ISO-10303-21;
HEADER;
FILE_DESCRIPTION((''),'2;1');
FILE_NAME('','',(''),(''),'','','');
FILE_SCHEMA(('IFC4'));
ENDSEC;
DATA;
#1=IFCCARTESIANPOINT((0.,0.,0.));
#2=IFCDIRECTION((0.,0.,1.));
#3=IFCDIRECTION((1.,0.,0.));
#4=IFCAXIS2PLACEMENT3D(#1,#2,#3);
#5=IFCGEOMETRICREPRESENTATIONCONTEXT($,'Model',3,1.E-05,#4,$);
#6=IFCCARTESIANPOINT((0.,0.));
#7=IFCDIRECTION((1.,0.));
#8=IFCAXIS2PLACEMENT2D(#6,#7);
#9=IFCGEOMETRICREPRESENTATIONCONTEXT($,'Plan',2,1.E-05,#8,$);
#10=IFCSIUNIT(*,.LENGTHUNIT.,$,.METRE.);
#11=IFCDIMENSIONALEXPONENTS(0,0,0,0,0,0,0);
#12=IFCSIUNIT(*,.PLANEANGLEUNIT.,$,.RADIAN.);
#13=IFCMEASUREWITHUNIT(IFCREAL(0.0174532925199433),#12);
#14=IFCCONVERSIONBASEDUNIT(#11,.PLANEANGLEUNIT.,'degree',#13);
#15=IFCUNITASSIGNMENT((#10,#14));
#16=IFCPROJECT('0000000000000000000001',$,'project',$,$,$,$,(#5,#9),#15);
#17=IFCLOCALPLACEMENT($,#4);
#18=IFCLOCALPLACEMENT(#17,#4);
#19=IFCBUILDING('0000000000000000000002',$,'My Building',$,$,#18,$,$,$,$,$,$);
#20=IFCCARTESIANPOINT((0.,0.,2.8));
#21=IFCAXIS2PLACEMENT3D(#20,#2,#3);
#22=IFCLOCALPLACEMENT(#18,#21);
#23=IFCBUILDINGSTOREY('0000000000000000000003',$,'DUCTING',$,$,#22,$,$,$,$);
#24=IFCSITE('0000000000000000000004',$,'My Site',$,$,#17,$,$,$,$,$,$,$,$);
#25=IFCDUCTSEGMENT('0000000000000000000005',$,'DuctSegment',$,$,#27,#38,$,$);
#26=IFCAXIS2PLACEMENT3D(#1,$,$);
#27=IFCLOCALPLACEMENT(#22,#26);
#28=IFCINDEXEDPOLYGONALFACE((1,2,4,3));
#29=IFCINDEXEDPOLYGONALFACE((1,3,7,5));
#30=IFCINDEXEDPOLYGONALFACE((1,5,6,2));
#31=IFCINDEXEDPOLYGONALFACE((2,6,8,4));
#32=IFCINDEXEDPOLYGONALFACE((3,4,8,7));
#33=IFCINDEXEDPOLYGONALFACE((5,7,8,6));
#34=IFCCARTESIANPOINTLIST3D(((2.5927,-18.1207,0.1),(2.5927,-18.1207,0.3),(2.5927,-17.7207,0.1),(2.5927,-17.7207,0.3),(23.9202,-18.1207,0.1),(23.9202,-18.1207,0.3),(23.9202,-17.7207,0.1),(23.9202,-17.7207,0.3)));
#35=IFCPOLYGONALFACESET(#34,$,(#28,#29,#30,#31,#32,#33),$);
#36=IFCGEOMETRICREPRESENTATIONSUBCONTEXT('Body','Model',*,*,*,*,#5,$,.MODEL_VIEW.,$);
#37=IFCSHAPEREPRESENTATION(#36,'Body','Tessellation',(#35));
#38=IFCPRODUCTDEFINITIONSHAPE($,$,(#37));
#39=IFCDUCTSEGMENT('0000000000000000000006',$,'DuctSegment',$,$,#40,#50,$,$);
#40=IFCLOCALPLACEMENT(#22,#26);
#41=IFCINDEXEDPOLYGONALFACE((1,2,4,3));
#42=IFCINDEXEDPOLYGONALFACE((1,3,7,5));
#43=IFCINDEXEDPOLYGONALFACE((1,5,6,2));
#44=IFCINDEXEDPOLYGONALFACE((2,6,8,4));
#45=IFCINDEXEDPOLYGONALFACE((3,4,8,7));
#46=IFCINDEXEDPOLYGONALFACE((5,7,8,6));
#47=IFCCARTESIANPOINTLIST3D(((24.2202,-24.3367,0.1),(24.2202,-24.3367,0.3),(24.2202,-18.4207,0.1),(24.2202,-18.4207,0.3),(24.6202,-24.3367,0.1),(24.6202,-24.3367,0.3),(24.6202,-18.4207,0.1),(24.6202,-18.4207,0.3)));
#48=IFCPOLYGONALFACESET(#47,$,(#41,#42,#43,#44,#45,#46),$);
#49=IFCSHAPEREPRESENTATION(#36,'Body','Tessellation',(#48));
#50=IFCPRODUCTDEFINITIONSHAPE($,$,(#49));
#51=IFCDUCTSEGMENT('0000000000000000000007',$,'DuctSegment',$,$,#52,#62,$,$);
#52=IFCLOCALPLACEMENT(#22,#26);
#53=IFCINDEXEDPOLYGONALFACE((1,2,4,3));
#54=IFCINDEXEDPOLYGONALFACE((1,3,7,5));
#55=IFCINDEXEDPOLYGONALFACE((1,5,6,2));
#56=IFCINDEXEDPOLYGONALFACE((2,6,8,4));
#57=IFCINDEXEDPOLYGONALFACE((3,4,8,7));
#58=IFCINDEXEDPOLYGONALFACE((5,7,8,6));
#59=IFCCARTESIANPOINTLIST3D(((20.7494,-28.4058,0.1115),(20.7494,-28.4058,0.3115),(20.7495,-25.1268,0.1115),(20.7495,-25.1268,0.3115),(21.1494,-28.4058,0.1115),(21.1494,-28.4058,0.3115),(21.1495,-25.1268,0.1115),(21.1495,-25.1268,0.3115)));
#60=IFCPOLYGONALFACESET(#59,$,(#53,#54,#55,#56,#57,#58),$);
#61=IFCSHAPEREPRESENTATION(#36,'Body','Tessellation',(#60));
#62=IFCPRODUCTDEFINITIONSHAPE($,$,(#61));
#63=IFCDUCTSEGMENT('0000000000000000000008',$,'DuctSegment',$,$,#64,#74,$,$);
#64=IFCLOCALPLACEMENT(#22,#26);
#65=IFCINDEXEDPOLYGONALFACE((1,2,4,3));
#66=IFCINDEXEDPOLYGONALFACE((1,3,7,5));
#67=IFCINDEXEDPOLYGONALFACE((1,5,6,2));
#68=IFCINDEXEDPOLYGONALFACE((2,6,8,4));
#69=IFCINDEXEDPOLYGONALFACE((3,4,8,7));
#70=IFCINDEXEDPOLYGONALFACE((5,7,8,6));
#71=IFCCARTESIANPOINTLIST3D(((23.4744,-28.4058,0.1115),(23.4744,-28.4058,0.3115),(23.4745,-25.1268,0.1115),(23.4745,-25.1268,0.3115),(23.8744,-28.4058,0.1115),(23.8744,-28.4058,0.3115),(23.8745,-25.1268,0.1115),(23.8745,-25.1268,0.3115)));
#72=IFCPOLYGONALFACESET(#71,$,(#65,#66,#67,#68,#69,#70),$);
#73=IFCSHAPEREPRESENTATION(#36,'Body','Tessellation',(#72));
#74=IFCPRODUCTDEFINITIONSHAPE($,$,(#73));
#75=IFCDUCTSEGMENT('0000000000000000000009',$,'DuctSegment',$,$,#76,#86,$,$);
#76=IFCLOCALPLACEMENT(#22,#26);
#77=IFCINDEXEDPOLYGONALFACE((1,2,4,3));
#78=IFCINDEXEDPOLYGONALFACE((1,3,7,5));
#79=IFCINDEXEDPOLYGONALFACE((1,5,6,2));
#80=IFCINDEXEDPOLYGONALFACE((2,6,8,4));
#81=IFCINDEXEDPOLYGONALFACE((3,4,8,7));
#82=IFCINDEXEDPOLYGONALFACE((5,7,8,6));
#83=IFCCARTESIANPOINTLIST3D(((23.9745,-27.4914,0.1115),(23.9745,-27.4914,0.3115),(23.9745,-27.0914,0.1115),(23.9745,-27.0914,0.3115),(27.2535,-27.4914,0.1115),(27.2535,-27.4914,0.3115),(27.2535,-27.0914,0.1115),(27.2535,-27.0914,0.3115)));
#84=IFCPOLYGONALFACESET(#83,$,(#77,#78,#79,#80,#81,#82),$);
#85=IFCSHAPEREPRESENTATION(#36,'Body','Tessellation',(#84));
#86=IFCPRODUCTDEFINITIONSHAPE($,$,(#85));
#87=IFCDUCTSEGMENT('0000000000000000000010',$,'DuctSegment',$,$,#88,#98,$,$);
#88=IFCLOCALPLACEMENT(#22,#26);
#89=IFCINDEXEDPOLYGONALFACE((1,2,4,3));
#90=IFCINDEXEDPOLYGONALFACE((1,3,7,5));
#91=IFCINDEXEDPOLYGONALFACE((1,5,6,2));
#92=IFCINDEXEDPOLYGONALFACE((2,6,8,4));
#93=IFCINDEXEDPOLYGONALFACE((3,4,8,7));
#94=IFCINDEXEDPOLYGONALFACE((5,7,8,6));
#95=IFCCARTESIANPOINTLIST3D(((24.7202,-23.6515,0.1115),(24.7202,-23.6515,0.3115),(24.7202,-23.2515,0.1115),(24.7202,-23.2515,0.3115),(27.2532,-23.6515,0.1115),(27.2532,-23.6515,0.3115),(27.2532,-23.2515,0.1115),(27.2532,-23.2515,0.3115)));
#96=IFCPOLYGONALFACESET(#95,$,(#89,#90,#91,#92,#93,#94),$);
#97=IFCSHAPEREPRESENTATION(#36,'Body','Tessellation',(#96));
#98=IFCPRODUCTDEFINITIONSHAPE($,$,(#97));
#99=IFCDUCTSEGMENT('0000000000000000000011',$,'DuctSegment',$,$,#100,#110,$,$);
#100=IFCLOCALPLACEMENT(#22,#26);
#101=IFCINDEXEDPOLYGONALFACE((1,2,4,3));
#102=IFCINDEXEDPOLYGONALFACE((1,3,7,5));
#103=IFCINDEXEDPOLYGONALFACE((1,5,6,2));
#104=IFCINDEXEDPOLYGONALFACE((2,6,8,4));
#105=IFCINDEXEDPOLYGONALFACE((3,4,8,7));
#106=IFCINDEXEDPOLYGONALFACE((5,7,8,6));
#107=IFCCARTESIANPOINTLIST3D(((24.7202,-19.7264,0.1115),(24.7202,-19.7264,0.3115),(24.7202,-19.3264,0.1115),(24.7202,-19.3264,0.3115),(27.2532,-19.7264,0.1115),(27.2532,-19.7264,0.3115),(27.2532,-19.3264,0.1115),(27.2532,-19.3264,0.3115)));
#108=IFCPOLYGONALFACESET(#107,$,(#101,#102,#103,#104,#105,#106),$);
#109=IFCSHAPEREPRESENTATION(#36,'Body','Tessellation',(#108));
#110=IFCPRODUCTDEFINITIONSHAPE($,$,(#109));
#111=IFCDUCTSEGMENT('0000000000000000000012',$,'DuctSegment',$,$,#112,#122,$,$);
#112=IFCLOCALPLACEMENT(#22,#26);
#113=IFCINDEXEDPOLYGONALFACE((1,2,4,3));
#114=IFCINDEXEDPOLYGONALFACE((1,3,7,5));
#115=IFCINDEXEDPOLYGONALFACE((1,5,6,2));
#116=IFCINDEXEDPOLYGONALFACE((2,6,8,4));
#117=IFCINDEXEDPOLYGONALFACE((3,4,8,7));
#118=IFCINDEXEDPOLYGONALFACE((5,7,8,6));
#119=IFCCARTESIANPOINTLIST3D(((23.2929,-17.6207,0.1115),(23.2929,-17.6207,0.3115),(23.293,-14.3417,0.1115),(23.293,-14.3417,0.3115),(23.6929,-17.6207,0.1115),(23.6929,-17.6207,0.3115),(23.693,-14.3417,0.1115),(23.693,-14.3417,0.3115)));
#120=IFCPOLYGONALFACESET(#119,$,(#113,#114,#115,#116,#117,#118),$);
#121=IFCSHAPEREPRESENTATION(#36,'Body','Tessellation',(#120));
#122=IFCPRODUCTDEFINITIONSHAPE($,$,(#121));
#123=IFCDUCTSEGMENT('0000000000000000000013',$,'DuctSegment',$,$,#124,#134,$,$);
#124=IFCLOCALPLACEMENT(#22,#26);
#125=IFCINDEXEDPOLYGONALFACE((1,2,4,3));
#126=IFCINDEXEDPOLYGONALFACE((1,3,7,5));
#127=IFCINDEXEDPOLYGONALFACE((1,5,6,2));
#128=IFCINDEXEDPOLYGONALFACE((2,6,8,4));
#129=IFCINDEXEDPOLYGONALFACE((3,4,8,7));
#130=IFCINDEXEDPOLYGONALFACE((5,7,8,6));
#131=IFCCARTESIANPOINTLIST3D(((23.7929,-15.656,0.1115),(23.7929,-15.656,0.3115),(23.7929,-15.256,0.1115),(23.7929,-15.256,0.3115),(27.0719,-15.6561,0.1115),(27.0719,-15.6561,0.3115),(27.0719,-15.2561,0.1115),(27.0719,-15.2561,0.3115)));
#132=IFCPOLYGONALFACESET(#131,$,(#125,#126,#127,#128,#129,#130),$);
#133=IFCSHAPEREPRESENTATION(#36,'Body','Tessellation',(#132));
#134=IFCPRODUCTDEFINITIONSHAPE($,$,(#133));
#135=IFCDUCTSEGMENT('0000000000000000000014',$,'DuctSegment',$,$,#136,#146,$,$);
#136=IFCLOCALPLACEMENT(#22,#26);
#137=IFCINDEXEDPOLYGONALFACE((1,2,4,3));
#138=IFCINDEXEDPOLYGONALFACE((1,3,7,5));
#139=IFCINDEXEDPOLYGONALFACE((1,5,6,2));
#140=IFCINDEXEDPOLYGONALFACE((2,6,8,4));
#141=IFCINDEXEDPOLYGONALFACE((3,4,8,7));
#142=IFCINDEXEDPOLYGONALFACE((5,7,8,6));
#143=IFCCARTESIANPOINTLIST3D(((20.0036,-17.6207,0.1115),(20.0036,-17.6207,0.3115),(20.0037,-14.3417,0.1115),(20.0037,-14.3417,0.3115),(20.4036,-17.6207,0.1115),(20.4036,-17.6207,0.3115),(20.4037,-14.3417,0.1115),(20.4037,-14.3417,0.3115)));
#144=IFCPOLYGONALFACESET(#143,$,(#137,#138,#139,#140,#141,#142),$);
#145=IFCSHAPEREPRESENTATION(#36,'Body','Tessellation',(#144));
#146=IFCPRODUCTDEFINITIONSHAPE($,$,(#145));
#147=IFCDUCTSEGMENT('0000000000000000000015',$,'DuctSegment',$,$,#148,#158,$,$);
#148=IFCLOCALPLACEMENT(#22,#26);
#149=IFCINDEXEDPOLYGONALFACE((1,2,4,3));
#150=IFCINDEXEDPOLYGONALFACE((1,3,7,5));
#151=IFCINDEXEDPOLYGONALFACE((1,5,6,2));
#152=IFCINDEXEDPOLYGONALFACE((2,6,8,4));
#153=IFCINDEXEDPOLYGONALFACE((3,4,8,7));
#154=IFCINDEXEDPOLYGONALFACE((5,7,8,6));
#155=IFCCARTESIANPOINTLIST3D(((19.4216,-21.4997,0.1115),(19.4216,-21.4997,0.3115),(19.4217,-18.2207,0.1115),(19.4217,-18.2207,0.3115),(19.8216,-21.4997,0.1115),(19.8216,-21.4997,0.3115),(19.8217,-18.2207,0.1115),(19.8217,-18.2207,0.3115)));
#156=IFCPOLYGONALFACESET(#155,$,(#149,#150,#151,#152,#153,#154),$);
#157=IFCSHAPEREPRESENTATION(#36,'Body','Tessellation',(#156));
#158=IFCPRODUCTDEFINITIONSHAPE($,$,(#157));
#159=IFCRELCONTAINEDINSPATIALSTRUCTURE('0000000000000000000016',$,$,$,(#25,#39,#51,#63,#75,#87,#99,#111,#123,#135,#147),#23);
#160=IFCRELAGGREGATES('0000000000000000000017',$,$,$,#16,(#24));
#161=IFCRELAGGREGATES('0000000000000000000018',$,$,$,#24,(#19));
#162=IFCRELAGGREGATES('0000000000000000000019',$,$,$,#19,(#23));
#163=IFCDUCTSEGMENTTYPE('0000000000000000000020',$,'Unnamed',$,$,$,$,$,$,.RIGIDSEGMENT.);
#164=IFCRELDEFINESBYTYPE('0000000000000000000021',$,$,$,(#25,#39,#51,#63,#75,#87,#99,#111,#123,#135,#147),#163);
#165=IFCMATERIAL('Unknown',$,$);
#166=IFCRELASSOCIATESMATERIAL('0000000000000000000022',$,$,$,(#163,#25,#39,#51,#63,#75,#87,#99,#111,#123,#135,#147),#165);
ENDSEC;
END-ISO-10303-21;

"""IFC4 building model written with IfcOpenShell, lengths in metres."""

from ifc_helpers import new_model, entity, si_unit, converted_unit, frame, origin_with_axes, origin_2d_with_axis, place, context, subcontext, project, spatial, rectangle, extrude, material, material_profile, profile_set, profile_usage, type_object, element, save


model = new_model("IFC4")

# Units and contexts
model_context = context("Model", 3, precision=1e-05, world=origin_with_axes())
plan_context = context("Plan", 2, precision=1e-05, world=origin_2d_with_axis())
body_context = subcontext(model_context, "Body", "Model", "MODEL_VIEW")
ifc_project = project(units=[si_unit("LENGTHUNIT", "METRE"), converted_unit("PLANEANGLEUNIT", "degree", entity("IfcReal", 0.0174532925199433), si_unit("PLANEANGLEUNIT", "RADIAN"), dimensions=[0, 0, 0, 0, 0, 0, 0])], contexts=[model_context, plan_context])

# Site, building, storey
site_placement = place(None, origin_with_axes())
site = spatial("IfcSite", under=ifc_project, at=site_placement, Name="My Site")
building_placement = place(site_placement, origin_with_axes())
building = spatial("IfcBuilding", under=site, at=building_placement, Name="My Building")
storey_placement = place(building_placement, frame((0.0, 0.0, 2.8), z_axis=(0.0, 0.0, 1.0), x_axis=(1.0, 0.0, 0.0)))
storey = spatial("IfcBuildingStorey", under=building, at=storey_placement, Name="DUCTING")

# Duct segments
ifc_material = material(Name="Unknown")
ifc_material_profile_1 = material_profile(ifc_material, rectangle(XDim=0.4, YDim=0.2))
ifc_profile_set_1 = profile_set([ifc_material_profile_1])
ifc_profile_usage_1 = profile_usage(ifc_profile_set_1, cardinal=5)
duct_segment_type = type_object("IfcDuctSegmentType", Name="Unnamed", PredefinedType="RIGIDSEGMENT", material=ifc_profile_set_1)
duct_segment_1_placement = place(storey_placement, frame((23.9202, -17.9207, 0.2), z_axis=(-1.0, 0.0, 0.0), x_axis=(0.0, -1.0, 0.0)))
element("IfcDuctSegment", 1, at=duct_segment_1_placement, inside=storey, type_object=duct_segment_type, material=ifc_profile_usage_1, Name="DuctSegment", context=body_context, shape_type="SweptSolid", body=[
    extrude(rectangle(XDim=0.4, YDim=0.2), origin_with_axes(), (0.0, 0.0, 1.0), 21.3274),
])
ifc_profile_usage_2 = profile_usage(ifc_profile_set_1, cardinal=5)
duct_segment_2_placement = place(storey_placement, frame((24.4202, -24.3367, 0.2), z_axis=(0.0, 1.0, 0.0), x_axis=(-1.0, 0.0, 0.0)))
element("IfcDuctSegment", 2, at=duct_segment_2_placement, inside=storey, type_object=duct_segment_type, material=ifc_profile_usage_2, Name="DuctSegment", context=body_context, shape_type="SweptSolid", body=[
    extrude(rectangle(XDim=0.4, YDim=0.2), origin_with_axes(), (0.0, 0.0, 1.0), 5.916),
])
ifc_profile_usage_3 = profile_usage(ifc_profile_set_1, cardinal=5)
duct_segment_3_placement = place(storey_placement, frame((20.9495, -25.1268, 0.2115), z_axis=(-0.000018, -1.0, 0.000001), x_axis=(1.0, -0.000018, 0.0)))
element("IfcDuctSegment", 3, at=duct_segment_3_placement, inside=storey, type_object=duct_segment_type, material=ifc_profile_usage_3, Name="DuctSegment", context=body_context, shape_type="SweptSolid", body=[
    extrude(rectangle(XDim=0.4, YDim=0.2), origin_with_axes(), (0.0, 0.0, 1.0), 3.279),
])
ifc_profile_usage_4 = profile_usage(ifc_profile_set_1, cardinal=5)
duct_segment_4_placement = place(storey_placement, frame((23.6745, -25.1268, 0.2115), z_axis=(-0.000018, -1.0, 0.000001), x_axis=(1.0, -0.000018, 0.0)))
element("IfcDuctSegment", 4, at=duct_segment_4_placement, inside=storey, type_object=duct_segment_type, material=ifc_profile_usage_4, Name="DuctSegment", context=body_context, shape_type="SweptSolid", body=[
    extrude(rectangle(XDim=0.4, YDim=0.2), origin_with_axes(), (0.0, 0.0, 1.0), 3.279),
])
ifc_profile_usage_5 = profile_usage(ifc_profile_set_1, cardinal=5)
duct_segment_5_placement = place(storey_placement, frame((23.9745, -27.2914, 0.2115), z_axis=(1.0, -0.000014, 0.000001), x_axis=(0.000014, 1.0, 0.0)))
element("IfcDuctSegment", 5, at=duct_segment_5_placement, inside=storey, type_object=duct_segment_type, material=ifc_profile_usage_5, Name="DuctSegment", context=body_context, shape_type="SweptSolid", body=[
    extrude(rectangle(XDim=0.4, YDim=0.2), origin_with_axes(), (0.0, 0.0, 1.0), 3.279),
])
ifc_profile_usage_6 = profile_usage(ifc_profile_set_1, cardinal=5)
duct_segment_6_placement = place(storey_placement, frame((24.7202, -23.4515, 0.2115), z_axis=(1.0, 0.0, 0.0), x_axis=(0.0, 1.0, 0.0)))
element("IfcDuctSegment", 6, at=duct_segment_6_placement, inside=storey, type_object=duct_segment_type, material=ifc_profile_usage_6, Name="DuctSegment", context=body_context, shape_type="SweptSolid", body=[
    extrude(rectangle(XDim=0.4, YDim=0.2), origin_with_axes(), (0.0, 0.0, 1.0), 2.533),
])
ifc_profile_usage_7 = profile_usage(ifc_profile_set_1, cardinal=5)
duct_segment_7_placement = place(storey_placement, frame((24.7202, -19.5264, 0.2115), z_axis=(1.0, 0.0, 0.0), x_axis=(0.0, 1.0, 0.0)))
element("IfcDuctSegment", 7, at=duct_segment_7_placement, inside=storey, type_object=duct_segment_type, material=ifc_profile_usage_7, Name="DuctSegment", context=body_context, shape_type="SweptSolid", body=[
    extrude(rectangle(XDim=0.4, YDim=0.2), origin_with_axes(), (0.0, 0.0, 1.0), 2.533),
])
ifc_profile_usage_8 = profile_usage(ifc_profile_set_1, cardinal=5)
duct_segment_8_placement = place(storey_placement, frame((23.4929, -17.6207, 0.2115), z_axis=(0.000025, 1.0, 0.000001), x_axis=(-1.0, 0.000025, 0.0)))
element("IfcDuctSegment", 8, at=duct_segment_8_placement, inside=storey, type_object=duct_segment_type, material=ifc_profile_usage_8, Name="DuctSegment", context=body_context, shape_type="SweptSolid", body=[
    extrude(rectangle(XDim=0.4, YDim=0.2), origin_with_axes(), (0.0, 0.0, 1.0), 3.279),
])
ifc_profile_usage_9 = profile_usage(ifc_profile_set_1, cardinal=5)
duct_segment_9_placement = place(storey_placement, frame((23.7929, -15.456, 0.2115), z_axis=(1.0, -0.000026, 0.000001), x_axis=(0.000026, 1.0, 0.0)))
element("IfcDuctSegment", 9, at=duct_segment_9_placement, inside=storey, type_object=duct_segment_type, material=ifc_profile_usage_9, Name="DuctSegment", context=body_context, shape_type="SweptSolid", body=[
    extrude(rectangle(XDim=0.4, YDim=0.2), origin_with_axes(), (0.0, 0.0, 1.0), 3.279),
])
ifc_profile_usage_10 = profile_usage(ifc_profile_set_1, cardinal=5)
duct_segment_10_placement = place(storey_placement, frame((20.2036, -17.6207, 0.2115), z_axis=(0.000025, 1.0, 0.000001), x_axis=(-1.0, 0.000025, 0.0)))
element("IfcDuctSegment", 10, at=duct_segment_10_placement, inside=storey, type_object=duct_segment_type, material=ifc_profile_usage_10, Name="DuctSegment", context=body_context, shape_type="SweptSolid", body=[
    extrude(rectangle(XDim=0.4, YDim=0.2), origin_with_axes(), (0.0, 0.0, 1.0), 3.279),
])
ifc_profile_usage_11 = profile_usage(ifc_profile_set_1, cardinal=5)
duct_segment_11_placement = place(storey_placement, frame((19.6217, -18.2207, 0.2115), z_axis=(-0.000018, -1.0, 0.000001), x_axis=(1.0, -0.000018, 0.0)))
element("IfcDuctSegment", 11, at=duct_segment_11_placement, inside=storey, type_object=duct_segment_type, material=ifc_profile_usage_11, Name="DuctSegment", context=body_context, shape_type="SweptSolid", body=[
    extrude(rectangle(XDim=0.4, YDim=0.2), origin_with_axes(), (0.0, 0.0, 1.0), 3.279),
])

save(model, "model.ifc")
